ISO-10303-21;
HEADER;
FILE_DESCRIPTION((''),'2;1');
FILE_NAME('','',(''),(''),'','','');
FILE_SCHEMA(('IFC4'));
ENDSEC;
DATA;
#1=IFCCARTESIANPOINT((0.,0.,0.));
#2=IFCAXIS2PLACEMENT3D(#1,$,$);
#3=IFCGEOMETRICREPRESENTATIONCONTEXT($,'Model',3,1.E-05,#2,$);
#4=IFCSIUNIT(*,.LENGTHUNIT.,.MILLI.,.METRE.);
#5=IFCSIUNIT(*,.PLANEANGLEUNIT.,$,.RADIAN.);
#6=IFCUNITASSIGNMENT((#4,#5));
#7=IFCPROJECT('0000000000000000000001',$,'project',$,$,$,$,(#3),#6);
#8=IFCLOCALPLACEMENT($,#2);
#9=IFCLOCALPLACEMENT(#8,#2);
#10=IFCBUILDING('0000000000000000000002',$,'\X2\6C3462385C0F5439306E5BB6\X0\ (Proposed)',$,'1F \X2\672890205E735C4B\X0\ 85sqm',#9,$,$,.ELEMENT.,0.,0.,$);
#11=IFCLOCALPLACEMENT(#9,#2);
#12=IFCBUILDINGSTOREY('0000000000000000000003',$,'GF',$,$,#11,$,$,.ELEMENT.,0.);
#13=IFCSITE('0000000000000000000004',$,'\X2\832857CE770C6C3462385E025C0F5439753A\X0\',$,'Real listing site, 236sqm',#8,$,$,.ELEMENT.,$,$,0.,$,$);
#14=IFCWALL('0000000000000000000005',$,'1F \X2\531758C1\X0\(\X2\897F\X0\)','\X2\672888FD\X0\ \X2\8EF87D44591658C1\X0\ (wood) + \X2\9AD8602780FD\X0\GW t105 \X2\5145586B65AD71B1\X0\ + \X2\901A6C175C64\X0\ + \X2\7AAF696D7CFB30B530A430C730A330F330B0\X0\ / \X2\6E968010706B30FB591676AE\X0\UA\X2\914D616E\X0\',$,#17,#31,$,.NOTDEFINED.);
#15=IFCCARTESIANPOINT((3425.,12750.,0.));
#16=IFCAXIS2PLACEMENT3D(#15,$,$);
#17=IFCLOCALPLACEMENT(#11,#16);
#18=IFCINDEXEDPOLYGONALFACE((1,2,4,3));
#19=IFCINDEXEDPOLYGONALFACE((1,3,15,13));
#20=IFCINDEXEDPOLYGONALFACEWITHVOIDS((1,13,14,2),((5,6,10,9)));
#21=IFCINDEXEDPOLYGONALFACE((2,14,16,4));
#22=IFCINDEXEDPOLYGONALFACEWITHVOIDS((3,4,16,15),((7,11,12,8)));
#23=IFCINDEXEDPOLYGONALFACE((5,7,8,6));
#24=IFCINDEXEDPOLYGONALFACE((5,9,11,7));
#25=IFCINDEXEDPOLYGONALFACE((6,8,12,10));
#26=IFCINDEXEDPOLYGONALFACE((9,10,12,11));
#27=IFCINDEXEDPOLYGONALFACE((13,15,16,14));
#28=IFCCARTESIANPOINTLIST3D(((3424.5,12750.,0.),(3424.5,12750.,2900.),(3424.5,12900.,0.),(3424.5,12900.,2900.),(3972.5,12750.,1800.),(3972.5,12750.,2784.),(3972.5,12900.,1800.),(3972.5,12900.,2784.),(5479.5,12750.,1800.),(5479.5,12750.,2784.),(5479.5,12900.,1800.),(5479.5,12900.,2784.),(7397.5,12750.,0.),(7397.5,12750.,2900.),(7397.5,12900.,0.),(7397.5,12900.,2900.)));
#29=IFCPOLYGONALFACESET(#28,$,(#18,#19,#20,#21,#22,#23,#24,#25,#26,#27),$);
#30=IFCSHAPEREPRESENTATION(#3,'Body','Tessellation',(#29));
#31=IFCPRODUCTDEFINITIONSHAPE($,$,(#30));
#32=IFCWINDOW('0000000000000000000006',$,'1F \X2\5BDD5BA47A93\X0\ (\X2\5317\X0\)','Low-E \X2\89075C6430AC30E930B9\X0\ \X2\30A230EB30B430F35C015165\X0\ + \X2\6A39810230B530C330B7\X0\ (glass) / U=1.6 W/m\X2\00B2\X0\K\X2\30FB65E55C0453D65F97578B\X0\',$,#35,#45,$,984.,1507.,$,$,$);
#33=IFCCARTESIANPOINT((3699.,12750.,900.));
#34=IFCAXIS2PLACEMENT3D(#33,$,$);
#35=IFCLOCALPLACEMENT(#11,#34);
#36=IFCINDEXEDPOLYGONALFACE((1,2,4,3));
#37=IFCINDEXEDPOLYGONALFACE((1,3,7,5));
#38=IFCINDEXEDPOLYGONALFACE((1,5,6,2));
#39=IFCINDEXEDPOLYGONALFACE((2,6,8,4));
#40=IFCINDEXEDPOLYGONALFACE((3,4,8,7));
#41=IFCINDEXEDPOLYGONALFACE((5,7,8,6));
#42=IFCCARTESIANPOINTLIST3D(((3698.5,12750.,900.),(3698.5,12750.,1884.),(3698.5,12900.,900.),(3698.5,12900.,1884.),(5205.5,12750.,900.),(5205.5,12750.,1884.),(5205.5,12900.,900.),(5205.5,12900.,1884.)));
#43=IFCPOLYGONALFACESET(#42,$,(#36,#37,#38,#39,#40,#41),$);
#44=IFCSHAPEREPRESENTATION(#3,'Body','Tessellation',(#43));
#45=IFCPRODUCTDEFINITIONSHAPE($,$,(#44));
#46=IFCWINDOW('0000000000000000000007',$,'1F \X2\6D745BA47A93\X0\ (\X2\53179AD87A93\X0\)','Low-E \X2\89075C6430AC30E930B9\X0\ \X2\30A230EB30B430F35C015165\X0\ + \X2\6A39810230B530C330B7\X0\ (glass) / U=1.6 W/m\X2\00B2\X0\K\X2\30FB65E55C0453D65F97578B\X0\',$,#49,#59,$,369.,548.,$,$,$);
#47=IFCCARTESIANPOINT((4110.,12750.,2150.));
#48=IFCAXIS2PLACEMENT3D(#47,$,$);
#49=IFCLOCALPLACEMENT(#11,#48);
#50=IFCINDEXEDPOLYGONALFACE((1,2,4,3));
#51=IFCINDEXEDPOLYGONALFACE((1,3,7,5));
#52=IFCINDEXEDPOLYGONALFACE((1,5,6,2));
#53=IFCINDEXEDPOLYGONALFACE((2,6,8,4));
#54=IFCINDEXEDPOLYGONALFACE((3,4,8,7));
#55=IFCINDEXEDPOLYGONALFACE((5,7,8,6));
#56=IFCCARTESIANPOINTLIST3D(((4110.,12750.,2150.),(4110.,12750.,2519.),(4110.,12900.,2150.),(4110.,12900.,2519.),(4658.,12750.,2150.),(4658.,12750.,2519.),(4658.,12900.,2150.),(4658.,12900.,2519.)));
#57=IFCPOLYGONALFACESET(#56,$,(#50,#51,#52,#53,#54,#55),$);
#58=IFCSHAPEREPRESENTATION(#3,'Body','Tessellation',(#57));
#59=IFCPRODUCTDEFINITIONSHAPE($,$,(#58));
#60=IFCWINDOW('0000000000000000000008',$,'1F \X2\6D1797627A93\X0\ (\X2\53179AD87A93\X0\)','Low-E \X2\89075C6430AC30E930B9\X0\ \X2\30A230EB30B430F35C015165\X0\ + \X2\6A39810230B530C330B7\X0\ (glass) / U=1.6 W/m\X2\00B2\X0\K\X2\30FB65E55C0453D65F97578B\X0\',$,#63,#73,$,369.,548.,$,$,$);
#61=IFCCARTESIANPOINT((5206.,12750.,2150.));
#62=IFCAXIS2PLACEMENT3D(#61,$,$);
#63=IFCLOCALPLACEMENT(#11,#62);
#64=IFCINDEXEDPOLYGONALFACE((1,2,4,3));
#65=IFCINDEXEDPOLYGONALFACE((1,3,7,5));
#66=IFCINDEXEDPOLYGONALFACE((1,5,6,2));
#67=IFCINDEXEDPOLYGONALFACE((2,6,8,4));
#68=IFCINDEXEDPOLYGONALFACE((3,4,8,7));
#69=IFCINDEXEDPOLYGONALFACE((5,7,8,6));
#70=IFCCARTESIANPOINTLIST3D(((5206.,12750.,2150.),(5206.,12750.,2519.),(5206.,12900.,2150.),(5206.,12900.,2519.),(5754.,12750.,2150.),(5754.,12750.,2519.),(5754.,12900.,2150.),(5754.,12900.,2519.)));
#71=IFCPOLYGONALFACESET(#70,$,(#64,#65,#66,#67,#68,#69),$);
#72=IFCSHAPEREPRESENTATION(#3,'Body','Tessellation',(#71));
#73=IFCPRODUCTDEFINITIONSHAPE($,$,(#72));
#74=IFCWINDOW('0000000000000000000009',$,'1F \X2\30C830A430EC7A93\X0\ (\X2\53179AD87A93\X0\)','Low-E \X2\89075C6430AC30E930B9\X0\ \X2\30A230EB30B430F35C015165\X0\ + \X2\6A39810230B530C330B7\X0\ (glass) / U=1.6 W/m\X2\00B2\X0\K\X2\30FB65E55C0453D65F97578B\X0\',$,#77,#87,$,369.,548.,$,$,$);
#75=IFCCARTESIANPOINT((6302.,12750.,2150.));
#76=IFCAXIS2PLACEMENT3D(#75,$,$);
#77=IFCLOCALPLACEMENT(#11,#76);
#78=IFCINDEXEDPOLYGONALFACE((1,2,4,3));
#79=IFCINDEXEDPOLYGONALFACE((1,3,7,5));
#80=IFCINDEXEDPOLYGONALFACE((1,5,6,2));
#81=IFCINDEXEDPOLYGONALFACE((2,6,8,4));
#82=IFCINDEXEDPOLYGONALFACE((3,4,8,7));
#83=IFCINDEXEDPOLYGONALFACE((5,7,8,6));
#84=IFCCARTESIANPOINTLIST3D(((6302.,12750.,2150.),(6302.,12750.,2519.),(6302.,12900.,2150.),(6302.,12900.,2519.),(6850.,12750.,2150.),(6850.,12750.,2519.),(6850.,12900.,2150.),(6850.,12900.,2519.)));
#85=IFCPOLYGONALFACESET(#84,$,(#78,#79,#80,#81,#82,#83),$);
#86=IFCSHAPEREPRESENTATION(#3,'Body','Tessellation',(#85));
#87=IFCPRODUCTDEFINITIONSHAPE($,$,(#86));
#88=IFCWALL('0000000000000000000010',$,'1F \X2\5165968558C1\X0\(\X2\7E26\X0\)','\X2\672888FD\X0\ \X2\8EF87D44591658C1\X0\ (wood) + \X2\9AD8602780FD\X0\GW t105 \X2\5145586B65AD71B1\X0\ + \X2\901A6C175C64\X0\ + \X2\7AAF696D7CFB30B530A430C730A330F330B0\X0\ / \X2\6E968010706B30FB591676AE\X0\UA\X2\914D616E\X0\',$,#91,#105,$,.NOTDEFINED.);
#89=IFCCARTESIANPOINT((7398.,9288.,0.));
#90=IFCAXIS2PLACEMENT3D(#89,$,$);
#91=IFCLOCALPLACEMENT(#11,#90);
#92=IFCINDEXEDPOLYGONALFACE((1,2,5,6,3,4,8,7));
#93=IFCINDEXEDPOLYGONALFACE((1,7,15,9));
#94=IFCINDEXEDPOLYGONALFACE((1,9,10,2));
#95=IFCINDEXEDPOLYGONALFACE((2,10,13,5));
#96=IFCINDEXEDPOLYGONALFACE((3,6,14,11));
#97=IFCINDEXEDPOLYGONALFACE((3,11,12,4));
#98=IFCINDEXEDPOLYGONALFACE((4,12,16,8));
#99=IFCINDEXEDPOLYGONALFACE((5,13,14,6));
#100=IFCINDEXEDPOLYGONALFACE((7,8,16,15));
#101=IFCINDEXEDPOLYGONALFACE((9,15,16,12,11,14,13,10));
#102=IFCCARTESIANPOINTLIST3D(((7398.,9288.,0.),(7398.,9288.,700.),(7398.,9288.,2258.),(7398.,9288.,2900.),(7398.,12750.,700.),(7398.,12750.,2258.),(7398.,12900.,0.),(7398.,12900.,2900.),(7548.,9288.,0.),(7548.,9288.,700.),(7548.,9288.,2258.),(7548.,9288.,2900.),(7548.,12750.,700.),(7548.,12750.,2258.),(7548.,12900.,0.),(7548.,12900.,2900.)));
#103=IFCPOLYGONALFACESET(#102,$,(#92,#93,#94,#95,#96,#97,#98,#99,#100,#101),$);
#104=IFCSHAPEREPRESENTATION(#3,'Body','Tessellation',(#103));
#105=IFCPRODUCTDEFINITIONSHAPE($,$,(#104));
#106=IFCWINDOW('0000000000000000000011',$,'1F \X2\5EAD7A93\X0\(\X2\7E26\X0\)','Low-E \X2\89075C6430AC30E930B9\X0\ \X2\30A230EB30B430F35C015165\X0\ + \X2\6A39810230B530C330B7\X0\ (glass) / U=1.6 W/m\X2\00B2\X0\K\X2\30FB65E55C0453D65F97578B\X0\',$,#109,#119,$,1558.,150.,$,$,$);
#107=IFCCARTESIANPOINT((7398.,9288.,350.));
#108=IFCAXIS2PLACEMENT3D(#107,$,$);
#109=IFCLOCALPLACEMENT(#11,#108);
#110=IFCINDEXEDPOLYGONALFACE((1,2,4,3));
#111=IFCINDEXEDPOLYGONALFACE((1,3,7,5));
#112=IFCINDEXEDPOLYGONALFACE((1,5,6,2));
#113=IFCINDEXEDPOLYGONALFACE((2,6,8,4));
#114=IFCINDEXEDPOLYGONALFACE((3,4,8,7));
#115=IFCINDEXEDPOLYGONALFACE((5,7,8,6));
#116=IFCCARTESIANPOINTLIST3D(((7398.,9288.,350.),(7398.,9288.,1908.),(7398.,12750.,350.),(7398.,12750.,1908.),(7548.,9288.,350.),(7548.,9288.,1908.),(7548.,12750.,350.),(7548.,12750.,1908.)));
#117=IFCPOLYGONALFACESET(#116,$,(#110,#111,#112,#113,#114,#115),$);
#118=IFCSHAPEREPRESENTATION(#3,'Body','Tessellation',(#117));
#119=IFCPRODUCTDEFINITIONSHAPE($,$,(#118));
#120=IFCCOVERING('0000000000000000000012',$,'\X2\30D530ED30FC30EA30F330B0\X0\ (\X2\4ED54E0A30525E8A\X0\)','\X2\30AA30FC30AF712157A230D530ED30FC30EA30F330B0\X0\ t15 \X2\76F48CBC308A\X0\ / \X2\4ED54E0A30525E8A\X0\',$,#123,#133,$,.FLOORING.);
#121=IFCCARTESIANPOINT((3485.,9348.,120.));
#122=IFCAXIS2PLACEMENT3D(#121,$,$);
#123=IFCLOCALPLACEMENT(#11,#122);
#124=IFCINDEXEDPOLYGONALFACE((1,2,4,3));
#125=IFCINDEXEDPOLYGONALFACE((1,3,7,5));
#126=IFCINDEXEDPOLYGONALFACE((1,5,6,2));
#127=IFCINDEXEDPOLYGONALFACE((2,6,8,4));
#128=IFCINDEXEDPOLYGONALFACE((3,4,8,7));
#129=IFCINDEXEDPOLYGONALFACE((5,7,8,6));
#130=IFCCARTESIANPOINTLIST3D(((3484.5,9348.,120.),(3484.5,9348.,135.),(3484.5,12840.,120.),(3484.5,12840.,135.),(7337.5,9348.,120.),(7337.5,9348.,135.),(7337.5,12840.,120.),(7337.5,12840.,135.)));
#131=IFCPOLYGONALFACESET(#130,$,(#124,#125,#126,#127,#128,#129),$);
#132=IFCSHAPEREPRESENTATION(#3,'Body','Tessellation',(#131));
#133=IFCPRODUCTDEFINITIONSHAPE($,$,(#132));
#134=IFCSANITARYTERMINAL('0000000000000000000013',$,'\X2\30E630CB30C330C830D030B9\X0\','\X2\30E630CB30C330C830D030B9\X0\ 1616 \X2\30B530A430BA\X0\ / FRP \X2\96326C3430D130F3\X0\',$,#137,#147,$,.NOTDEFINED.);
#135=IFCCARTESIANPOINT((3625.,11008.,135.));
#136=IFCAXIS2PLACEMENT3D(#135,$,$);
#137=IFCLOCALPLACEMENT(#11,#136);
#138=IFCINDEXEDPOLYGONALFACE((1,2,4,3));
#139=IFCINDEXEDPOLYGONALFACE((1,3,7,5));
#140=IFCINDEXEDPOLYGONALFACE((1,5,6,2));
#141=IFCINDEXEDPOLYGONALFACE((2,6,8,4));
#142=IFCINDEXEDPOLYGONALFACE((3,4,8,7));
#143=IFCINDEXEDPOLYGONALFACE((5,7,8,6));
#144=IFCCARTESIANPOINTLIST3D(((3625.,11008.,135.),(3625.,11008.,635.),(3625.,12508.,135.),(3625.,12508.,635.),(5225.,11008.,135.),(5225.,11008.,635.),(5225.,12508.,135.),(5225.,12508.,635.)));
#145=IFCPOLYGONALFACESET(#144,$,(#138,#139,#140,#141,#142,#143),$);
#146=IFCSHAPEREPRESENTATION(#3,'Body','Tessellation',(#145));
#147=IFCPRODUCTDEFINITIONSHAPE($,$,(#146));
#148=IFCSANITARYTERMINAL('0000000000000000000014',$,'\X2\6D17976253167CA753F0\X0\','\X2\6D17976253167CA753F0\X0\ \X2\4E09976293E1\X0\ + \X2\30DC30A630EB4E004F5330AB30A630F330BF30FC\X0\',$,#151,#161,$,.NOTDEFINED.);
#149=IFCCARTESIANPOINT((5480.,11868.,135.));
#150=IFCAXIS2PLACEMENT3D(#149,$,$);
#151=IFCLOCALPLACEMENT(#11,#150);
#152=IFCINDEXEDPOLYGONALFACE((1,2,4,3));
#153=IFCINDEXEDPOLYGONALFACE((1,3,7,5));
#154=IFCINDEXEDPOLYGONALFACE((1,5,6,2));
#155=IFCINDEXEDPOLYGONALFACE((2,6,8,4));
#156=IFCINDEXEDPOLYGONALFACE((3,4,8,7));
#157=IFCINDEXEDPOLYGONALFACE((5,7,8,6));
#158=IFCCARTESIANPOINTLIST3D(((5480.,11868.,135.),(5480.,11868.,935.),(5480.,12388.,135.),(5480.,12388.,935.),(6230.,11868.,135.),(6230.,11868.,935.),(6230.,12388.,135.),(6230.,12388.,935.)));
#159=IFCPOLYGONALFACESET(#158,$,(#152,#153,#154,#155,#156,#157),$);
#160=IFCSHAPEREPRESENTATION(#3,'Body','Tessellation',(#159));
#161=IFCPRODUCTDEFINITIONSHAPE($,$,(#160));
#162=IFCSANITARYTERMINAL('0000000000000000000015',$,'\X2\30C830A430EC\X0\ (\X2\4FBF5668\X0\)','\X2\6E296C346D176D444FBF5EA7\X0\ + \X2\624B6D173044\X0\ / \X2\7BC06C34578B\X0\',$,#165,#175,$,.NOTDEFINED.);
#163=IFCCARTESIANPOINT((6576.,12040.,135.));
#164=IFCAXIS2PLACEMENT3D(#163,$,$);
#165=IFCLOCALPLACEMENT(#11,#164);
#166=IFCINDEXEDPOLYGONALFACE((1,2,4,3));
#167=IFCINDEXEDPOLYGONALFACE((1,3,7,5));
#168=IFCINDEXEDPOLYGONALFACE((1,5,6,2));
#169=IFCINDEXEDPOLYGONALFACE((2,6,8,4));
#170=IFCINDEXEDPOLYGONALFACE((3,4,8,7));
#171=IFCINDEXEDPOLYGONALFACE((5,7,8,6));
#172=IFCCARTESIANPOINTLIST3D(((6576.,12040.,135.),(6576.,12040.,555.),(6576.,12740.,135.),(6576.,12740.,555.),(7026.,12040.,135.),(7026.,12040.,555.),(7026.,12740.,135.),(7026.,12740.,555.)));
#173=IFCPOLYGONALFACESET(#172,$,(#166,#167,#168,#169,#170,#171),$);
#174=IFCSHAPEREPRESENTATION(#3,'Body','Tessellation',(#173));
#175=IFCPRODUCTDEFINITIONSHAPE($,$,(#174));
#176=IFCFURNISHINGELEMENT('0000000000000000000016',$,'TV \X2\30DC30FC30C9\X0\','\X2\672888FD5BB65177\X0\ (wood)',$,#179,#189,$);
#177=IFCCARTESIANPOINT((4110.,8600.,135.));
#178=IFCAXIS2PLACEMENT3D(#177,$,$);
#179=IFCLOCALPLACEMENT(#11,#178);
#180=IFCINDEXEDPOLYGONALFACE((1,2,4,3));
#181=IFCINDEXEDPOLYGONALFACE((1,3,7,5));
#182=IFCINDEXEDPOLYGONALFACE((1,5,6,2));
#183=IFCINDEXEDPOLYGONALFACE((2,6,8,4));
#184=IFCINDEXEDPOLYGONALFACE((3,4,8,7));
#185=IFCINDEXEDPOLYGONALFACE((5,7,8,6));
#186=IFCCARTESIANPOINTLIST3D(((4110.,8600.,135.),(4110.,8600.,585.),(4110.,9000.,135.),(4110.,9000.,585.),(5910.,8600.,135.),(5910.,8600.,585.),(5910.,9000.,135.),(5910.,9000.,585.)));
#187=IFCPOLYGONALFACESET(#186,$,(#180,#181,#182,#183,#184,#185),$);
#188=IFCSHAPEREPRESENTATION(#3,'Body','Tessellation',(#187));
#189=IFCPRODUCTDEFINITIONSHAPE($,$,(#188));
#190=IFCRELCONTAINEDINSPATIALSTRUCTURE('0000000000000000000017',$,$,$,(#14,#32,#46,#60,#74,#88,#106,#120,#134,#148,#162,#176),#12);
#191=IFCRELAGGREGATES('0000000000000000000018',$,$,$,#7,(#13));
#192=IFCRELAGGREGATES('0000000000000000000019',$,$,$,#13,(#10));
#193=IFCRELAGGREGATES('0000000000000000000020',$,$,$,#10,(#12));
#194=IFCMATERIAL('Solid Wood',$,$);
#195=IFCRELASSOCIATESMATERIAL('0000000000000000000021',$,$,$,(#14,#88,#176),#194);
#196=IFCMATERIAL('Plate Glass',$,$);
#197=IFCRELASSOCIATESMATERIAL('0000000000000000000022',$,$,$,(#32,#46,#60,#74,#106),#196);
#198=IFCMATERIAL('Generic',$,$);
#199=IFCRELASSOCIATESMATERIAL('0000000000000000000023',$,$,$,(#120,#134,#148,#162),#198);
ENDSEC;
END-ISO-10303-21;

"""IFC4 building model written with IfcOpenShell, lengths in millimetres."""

from ifc_helpers import new_model, si_unit, frame, frame_2d, origin, place, context, project, spatial, rectangle, extrude, material, element, fill, save


model = new_model("IFC4")

# Units and contexts
model_context = context("Model", 3, precision=1e-05, world=origin())
ifc_project = project(units=[si_unit("LENGTHUNIT", "METRE", prefix="MILLI"), si_unit("PLANEANGLEUNIT", "RADIAN")], contexts=[model_context])

# Site, building, storey
site_placement = place(None, origin())
site = spatial("IfcSite", under=ifc_project, at=site_placement, Name="茨城県水戸市小吹町", ObjectType="Real listing site, 236sqm", CompositionType="ELEMENT", RefElevation=0.0)
building_placement = place(site_placement, origin())
building = spatial("IfcBuilding", under=site, at=building_placement, Name="水戸小吹の家 (Proposed)", ObjectType="1F 木造平屋 85sqm", CompositionType="ELEMENT", ElevationOfRefHeight=0.0, ElevationOfTerrain=0.0)
storey_placement = place(building_placement, origin())
storey = spatial("IfcBuildingStorey", under=building, at=storey_placement, Name="GF", CompositionType="ELEMENT", Elevation=0.0)

# Shared definitions
ifc_material_1 = material(Name="Solid Wood")

# Wall, openings, windows
wall_1_placement = place(storey_placement, frame((3425.0, 12750.0, 0.0)))
wall_1 = element("IfcWall", 1, at=wall_1_placement, inside=storey, material=ifc_material_1, Name="1F 北壁(西)", Description="木製 軸組外壁 (wood) + 高性能GW t105 充填断熱 + 通気層 + 窯業系サイディング / 準耐火・外皮UA配慮", PredefinedType="NOTDEFINED", context=model_context, shape_type="SweptSolid", body=[
    extrude(rectangle(XDim=3973.0, YDim=150.0, at=frame_2d((1986.0, 75.0))), frame((3425.0, 12750.0, 0.0)), (0.0, 0.0, 1.0), 2900.0),
])
opening_1_placement = place(storey_placement, frame((3699.0, 12750.0, 900.0)))
opening_1 = element("IfcOpeningElement", 2, at=opening_1_placement, cuts=wall_1, PredefinedType="NOTDEFINED", context=model_context, shape_type="SweptSolid", body=[
    extrude(rectangle(XDim=1507.0, YDim=150.0, at=frame_2d((753.0, 75.0))), frame((3699.0, 12750.0, 900.0)), (0.0, 0.0, 1.0), 984.0),
])
opening_2_placement = place(storey_placement, frame((4110.0, 12750.0, 2150.0)))
opening_2 = element("IfcOpeningElement", 3, at=opening_2_placement, cuts=wall_1, PredefinedType="NOTDEFINED", context=model_context, shape_type="SweptSolid", body=[
    extrude(rectangle(XDim=548.0, YDim=150.0, at=frame_2d((274.0, 75.0))), frame((4110.0, 12750.0, 2150.0)), (0.0, 0.0, 1.0), 369.0),
])
opening_3_placement = place(storey_placement, frame((5206.0, 12750.0, 2150.0)))
opening_3 = element("IfcOpeningElement", 4, at=opening_3_placement, cuts=wall_1, PredefinedType="NOTDEFINED", context=model_context, shape_type="SweptSolid", body=[
    extrude(rectangle(XDim=548.0, YDim=150.0, at=frame_2d((274.0, 75.0))), frame((5206.0, 12750.0, 2150.0)), (0.0, 0.0, 1.0), 369.0),
])
opening_4_placement = place(storey_placement, frame((6302.0, 12750.0, 2150.0)))
opening_4 = element("IfcOpeningElement", 5, at=opening_4_placement, cuts=wall_1, PredefinedType="NOTDEFINED", context=model_context, shape_type="SweptSolid", body=[
    extrude(rectangle(XDim=548.0, YDim=150.0, at=frame_2d((274.0, 75.0))), frame((6302.0, 12750.0, 2150.0)), (0.0, 0.0, 1.0), 369.0),
])
ifc_material_2 = material(Name="Plate Glass")
window_1_placement = place(storey_placement, frame((3699.0, 12750.0, 900.0)))
window_1 = element("IfcWindow", 6, at=window_1_placement, inside=storey, material=ifc_material_2, Name="1F 寝室窓 (北)", Description="Low-E 複層ガラス アルゴン封入 + 樹脂サッシ (glass) / U=1.6 W/m²K・日射取得型", OverallHeight=984.0, OverallWidth=1507.0, context=model_context, shape_type="SweptSolid", body=[
    extrude(rectangle(XDim=1507.0, YDim=150.0, at=frame_2d((753.0, 75.0))), frame((3699.0, 12750.0, 900.0)), (0.0, 0.0, 1.0), 984.0),
])
fill(opening_1, window_1)
window_2_placement = place(storey_placement, frame((4110.0, 12750.0, 2150.0)))
window_2 = element("IfcWindow", 7, at=window_2_placement, inside=storey, material=ifc_material_2, Name="1F 浴室窓 (北高窓)", Description="Low-E 複層ガラス アルゴン封入 + 樹脂サッシ (glass) / U=1.6 W/m²K・日射取得型", OverallHeight=369.0, OverallWidth=548.0, context=model_context, shape_type="SweptSolid", body=[
    extrude(rectangle(XDim=548.0, YDim=150.0, at=frame_2d((274.0, 75.0))), frame((4110.0, 12750.0, 2150.0)), (0.0, 0.0, 1.0), 369.0),
])
fill(opening_2, window_2)
window_3_placement = place(storey_placement, frame((5206.0, 12750.0, 2150.0)))
window_3 = element("IfcWindow", 8, at=window_3_placement, inside=storey, material=ifc_material_2, Name="1F 洗面窓 (北高窓)", Description="Low-E 複層ガラス アルゴン封入 + 樹脂サッシ (glass) / U=1.6 W/m²K・日射取得型", OverallHeight=369.0, OverallWidth=548.0, context=model_context, shape_type="SweptSolid", body=[
    extrude(rectangle(XDim=548.0, YDim=150.0, at=frame_2d((274.0, 75.0))), frame((5206.0, 12750.0, 2150.0)), (0.0, 0.0, 1.0), 369.0),
])
fill(opening_3, window_3)
window_4_placement = place(storey_placement, frame((6302.0, 12750.0, 2150.0)))
window_4 = element("IfcWindow", 9, at=window_4_placement, inside=storey, material=ifc_material_2, Name="1F トイレ窓 (北高窓)", Description="Low-E 複層ガラス アルゴン封入 + 樹脂サッシ (glass) / U=1.6 W/m²K・日射取得型", OverallHeight=369.0, OverallWidth=548.0, context=model_context, shape_type="SweptSolid", body=[
    extrude(rectangle(XDim=548.0, YDim=150.0, at=frame_2d((274.0, 75.0))), frame((6302.0, 12750.0, 2150.0)), (0.0, 0.0, 1.0), 369.0),
])
fill(opening_4, window_4)

# Wall, opening, window
wall_2_placement = place(storey_placement, frame((7398.0, 9288.0, 0.0)))
wall_2 = element("IfcWall", 10, at=wall_2_placement, inside=storey, material=ifc_material_1, Name="1F 入隅壁(縦)", Description="木製 軸組外壁 (wood) + 高性能GW t105 充填断熱 + 通気層 + 窯業系サイディング / 準耐火・外皮UA配慮", PredefinedType="NOTDEFINED", context=model_context, shape_type="SweptSolid", body=[
    extrude(rectangle(XDim=150.0, YDim=3612.0, at=frame_2d((75.0, 1806.0))), frame((7398.0, 9288.0, 0.0)), (0.0, 0.0, 1.0), 2900.0),
])
opening_5_placement = place(storey_placement, frame((7398.0, 9288.0, 350.0)))
opening_5 = element("IfcOpeningElement", 11, at=opening_5_placement, cuts=wall_2, PredefinedType="NOTDEFINED", context=model_context, shape_type="SweptSolid", body=[
    extrude(rectangle(XDim=150.0, YDim=3462.0, at=frame_2d((75.0, 1731.0))), frame((7398.0, 9288.0, 350.0)), (0.0, 0.0, 1.0), 1558.0),
])
window_5_placement = place(storey_placement, frame((7398.0, 9288.0, 350.0)))
window_5 = element("IfcWindow", 12, at=window_5_placement, inside=storey, material=ifc_material_2, Name="1F 庭窓(縦)", Description="Low-E 複層ガラス アルゴン封入 + 樹脂サッシ (glass) / U=1.6 W/m²K・日射取得型", OverallHeight=1558.0, OverallWidth=150.0, context=model_context, shape_type="SweptSolid", body=[
    extrude(rectangle(XDim=150.0, YDim=3462.0, at=frame_2d((75.0, 1731.0))), frame((7398.0, 9288.0, 350.0)), (0.0, 0.0, 1.0), 1558.0),
])
fill(opening_5, window_5)

# Covering
ifc_material_3 = material(Name="Generic")
covering_placement = place(storey_placement, frame((3485.0, 9348.0, 120.0)))
element("IfcCovering", 13, at=covering_placement, inside=storey, material=ifc_material_3, Name="フローリング (仕上げ床)", Description="オーク無垢フローリング t15 直貼り / 仕上げ床", PredefinedType="FLOORING", context=model_context, shape_type="SweptSolid", body=[
    extrude(rectangle(XDim=3853.0, YDim=3492.0, at=frame_2d((1926.0, 1746.0))), frame((3485.0, 9348.0, 120.0)), (0.0, 0.0, 1.0), 15.0),
])

# Sanitary terminals
sanitary_terminal_1_placement = place(storey_placement, frame((3625.0, 11008.0, 135.0)))
element("IfcSanitaryTerminal", 14, at=sanitary_terminal_1_placement, inside=storey, material=ifc_material_3, Name="ユニットバス", Description="ユニットバス 1616 サイズ / FRP 防水パン", PredefinedType="NOTDEFINED", context=model_context, shape_type="SweptSolid", body=[
    extrude(rectangle(XDim=1600.0, YDim=1500.0, at=frame_2d((800.0, 750.0))), frame((3625.0, 11008.0, 135.0)), (0.0, 0.0, 1.0), 500.0),
])
sanitary_terminal_2_placement = place(storey_placement, frame((5480.0, 11868.0, 135.0)))
element("IfcSanitaryTerminal", 15, at=sanitary_terminal_2_placement, inside=storey, material=ifc_material_3, Name="洗面化粧台", Description="洗面化粧台 三面鏡 + ボウル一体カウンター", PredefinedType="NOTDEFINED", context=model_context, shape_type="SweptSolid", body=[
    extrude(rectangle(XDim=750.0, YDim=520.0, at=frame_2d((375.0, 260.0))), frame((5480.0, 11868.0, 135.0)), (0.0, 0.0, 1.0), 800.0),
])
sanitary_terminal_3_placement = place(storey_placement, frame((6576.0, 12040.0, 135.0)))
element("IfcSanitaryTerminal", 16, at=sanitary_terminal_3_placement, inside=storey, material=ifc_material_3, Name="トイレ (便器)", Description="温水洗浄便座 + 手洗い / 節水型", PredefinedType="NOTDEFINED", context=model_context, shape_type="SweptSolid", body=[
    extrude(rectangle(XDim=450.0, YDim=700.0, at=frame_2d((225.0, 350.0))), frame((6576.0, 12040.0, 135.0)), (0.0, 0.0, 1.0), 420.0),
])

# Furnishing element
furnishing_placement = place(storey_placement, frame((4110.0, 8600.0, 135.0)))
element("IfcFurnishingElement", 17, at=furnishing_placement, inside=storey, material=ifc_material_1, Name="TV ボード", Description="木製家具 (wood)", context=model_context, shape_type="SweptSolid", body=[
    extrude(rectangle(XDim=1800.0, YDim=400.0, at=frame_2d((900.0, 200.0))), frame((4110.0, 8600.0, 135.0)), (0.0, 0.0, 1.0), 450.0),
])

save(model, "model.ifc")
